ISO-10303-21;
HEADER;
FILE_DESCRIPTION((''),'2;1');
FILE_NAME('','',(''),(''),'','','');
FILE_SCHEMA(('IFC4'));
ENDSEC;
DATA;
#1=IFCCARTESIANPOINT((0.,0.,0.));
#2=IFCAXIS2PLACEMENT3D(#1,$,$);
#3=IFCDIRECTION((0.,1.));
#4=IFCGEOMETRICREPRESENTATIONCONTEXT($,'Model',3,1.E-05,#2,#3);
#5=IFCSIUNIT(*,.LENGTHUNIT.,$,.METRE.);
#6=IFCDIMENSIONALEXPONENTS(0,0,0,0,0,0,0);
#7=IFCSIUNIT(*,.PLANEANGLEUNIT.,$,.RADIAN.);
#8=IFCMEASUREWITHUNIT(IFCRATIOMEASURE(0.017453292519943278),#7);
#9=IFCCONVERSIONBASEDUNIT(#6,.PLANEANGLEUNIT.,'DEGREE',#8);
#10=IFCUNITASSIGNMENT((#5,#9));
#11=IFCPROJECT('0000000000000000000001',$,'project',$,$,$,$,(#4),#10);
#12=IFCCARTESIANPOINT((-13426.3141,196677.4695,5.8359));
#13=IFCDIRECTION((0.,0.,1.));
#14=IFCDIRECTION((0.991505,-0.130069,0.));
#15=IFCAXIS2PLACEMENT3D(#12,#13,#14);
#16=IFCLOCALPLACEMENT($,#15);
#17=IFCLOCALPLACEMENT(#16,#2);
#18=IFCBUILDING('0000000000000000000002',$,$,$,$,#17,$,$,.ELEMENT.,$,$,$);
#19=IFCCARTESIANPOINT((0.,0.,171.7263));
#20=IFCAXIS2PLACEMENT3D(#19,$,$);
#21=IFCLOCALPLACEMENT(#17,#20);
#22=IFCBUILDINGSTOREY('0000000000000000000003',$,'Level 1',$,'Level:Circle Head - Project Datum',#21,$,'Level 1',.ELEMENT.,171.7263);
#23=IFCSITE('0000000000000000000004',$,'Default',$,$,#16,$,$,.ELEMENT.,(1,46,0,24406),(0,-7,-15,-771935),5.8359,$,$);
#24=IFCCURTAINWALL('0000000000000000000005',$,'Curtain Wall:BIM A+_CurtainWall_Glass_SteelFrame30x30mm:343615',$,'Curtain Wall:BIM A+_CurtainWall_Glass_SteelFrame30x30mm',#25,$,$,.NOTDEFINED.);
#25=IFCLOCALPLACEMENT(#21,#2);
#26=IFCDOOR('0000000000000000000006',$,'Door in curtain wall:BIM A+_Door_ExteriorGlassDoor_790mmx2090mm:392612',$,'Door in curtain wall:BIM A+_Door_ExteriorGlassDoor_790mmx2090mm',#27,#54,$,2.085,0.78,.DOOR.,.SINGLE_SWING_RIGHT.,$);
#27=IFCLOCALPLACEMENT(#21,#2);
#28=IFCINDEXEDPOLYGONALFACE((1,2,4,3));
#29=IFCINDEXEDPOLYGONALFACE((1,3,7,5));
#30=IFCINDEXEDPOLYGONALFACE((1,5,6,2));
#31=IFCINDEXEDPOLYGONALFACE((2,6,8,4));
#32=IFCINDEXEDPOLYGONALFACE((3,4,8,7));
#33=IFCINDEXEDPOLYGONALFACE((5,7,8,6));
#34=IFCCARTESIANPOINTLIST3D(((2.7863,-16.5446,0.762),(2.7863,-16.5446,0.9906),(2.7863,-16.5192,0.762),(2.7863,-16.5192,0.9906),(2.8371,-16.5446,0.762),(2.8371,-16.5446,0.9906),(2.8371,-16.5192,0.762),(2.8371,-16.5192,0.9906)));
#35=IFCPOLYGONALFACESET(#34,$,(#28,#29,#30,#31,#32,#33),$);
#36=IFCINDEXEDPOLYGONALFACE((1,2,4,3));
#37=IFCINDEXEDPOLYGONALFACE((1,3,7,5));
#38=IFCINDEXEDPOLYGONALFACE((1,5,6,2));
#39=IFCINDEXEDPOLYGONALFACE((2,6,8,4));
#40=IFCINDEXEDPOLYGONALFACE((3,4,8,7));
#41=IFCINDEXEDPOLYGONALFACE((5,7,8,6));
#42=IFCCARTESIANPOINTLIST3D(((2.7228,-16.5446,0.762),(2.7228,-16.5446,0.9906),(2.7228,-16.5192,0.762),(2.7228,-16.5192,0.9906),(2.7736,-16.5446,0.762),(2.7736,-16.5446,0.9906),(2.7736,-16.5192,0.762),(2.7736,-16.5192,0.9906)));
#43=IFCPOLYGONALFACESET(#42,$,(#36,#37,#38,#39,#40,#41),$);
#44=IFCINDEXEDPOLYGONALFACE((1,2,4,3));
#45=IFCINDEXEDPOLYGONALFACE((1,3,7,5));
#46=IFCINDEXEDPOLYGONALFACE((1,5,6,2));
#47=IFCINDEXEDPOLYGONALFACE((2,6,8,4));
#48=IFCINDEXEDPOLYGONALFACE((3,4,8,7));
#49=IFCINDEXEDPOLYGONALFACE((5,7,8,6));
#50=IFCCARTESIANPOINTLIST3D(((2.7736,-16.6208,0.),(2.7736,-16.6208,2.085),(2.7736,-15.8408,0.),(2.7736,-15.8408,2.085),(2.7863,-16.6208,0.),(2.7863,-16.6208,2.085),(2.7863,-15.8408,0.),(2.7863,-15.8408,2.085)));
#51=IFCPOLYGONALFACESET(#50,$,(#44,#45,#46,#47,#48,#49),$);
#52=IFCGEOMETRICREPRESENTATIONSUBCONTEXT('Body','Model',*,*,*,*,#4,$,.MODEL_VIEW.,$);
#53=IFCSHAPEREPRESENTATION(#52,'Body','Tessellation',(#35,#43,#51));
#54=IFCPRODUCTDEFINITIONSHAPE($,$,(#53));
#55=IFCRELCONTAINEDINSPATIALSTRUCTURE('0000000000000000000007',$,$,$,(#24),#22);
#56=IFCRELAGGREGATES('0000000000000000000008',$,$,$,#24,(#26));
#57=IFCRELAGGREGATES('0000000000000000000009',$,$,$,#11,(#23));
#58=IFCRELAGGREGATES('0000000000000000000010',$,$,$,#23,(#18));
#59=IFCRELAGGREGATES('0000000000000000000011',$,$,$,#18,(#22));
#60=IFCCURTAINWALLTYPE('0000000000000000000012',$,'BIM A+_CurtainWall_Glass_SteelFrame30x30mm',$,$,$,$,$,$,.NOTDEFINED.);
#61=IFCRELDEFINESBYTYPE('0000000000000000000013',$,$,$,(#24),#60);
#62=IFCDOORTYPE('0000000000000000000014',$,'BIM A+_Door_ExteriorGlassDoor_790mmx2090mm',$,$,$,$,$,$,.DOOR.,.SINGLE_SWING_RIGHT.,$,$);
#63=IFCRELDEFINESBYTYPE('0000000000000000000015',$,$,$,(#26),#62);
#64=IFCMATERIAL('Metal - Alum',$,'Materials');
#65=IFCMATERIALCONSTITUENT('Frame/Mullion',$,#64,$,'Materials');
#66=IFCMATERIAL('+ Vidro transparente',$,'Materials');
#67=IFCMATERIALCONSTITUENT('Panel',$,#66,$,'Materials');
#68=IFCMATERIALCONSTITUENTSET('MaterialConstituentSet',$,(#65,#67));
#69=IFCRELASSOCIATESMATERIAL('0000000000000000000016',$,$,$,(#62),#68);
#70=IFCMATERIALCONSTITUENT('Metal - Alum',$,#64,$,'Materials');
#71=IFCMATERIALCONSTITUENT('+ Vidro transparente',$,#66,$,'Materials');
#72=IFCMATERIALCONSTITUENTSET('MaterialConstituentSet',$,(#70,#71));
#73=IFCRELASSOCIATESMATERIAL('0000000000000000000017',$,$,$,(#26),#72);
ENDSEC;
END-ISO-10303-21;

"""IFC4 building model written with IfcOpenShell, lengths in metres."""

from ifc_helpers import new_model, entity, si_unit, converted_unit, direction, frame, origin, place, context, subcontext, project, spatial, indexed_curve, outline, extrude, source, transform, mapped, material, constituent, constituent_set, type_object, type_shapes, element, aggregate, save


model = new_model("IFC4")

# Units and contexts
model_context = context("Model", 3, precision=1e-05, world=origin(), true_north=direction((0.0, 1.0)))
body_context = subcontext(model_context, "Body", "Model", "MODEL_VIEW")
ifc_project = project(units=[si_unit("LENGTHUNIT", "METRE"), converted_unit("PLANEANGLEUNIT", "DEGREE", entity("IfcRatioMeasure", 0.017453292519943278), si_unit("PLANEANGLEUNIT", "RADIAN"), dimensions=[0, 0, 0, 0, 0, 0, 0])], contexts=[model_context])

# Site, building, storey
site_placement = place(None, frame((-13426.3141, 196677.4695, 5.8359), z_axis=(0.0, 0.0, 1.0), x_axis=(0.991505, -0.130069, 0.0)))
site = spatial("IfcSite", under=ifc_project, at=site_placement, Name="Default", CompositionType="ELEMENT", RefLatitude=(1, 46, 0, 24406), RefLongitude=(0, -7, -15, -771935), RefElevation=5.8359)
building_placement = place(site_placement, origin())
building = spatial("IfcBuilding", under=site, at=building_placement, CompositionType="ELEMENT")
storey_placement = place(building_placement, frame((0.0, 0.0, 171.7263)))
storey = spatial("IfcBuildingStorey", under=building, at=storey_placement, Name="Level 1", ObjectType="Level:Circle Head - Project Datum", LongName="Level 1", CompositionType="ELEMENT", Elevation=171.7263)

# Shared definitions
curtain_wall_type_1 = type_object("IfcCurtainWallType", Name="BIM A+_CurtainWall_Glass_SteelFrame30x30mm", PredefinedType="NOTDEFINED")

# Curtain wall, door
curtain_wall_1_placement = place(storey_placement, frame((0.0, 0.0, -171.7263)))
curtain_wall_1 = element("IfcCurtainWall", 1, at=curtain_wall_1_placement, inside=storey, type_object=curtain_wall_type_1, Name="Curtain Wall:BIM A+_CurtainWall_Glass_SteelFrame30x30mm:343615", ObjectType="Curtain Wall:BIM A+_CurtainWall_Glass_SteelFrame30x30mm", PredefinedType="NOTDEFINED")
ifc_material_1 = material(Name="Metal - Alum", Category="Materials")
ifc_constituent_1 = constituent(ifc_material_1, Name="Metal - Alum", Category="Materials")
ifc_material_2 = material(Name="+ Vidro transparente", Category="Materials")
ifc_constituent_2 = constituent(ifc_material_2, Name="+ Vidro transparente", Category="Materials")
ifc_constituent_set_1 = constituent_set(constituents=[ifc_constituent_1, ifc_constituent_2], Name="MaterialConstituentSet")
ifc_constituent_3 = constituent(ifc_material_1, Name="Frame/Mullion", Category="Materials")
ifc_constituent_4 = constituent(ifc_material_2, Name="Panel", Category="Materials")
ifc_constituent_set_2 = constituent_set(constituents=[ifc_constituent_3, ifc_constituent_4], Name="MaterialConstituentSet")
door_type = type_object("IfcDoorType", Name="BIM A+_Door_ExteriorGlassDoor_790mmx2090mm", OperationType="SINGLE_SWING_RIGHT", PredefinedType="DOOR", material=ifc_constituent_set_2)
shared_shape_1 = source(origin(), body_context, "Body", "SweptSolid", [
    extrude(outline(indexed_curve([(-0.0254, -0.0127), (0.0254, -0.0127), (0.0254, 0.0127), (-0.0254, 0.0127), (-0.0254, -0.0127)], self_intersect=False)), frame((-0.3011, -0.0381, 0.762), z_axis=(0.0, 0.0, 1.0), x_axis=(0.0, 1.0, 0.0)), (0.0, 0.0, 1.0), 0.2286),
    extrude(outline(indexed_curve([(-0.0254, -0.0127), (0.0254, -0.0127), (0.0254, 0.0127), (-0.0254, 0.0127), (-0.0254, -0.0127)], self_intersect=False)), frame((-0.3011, 0.0254, 0.762), z_axis=(0.0, 0.0, 1.0), x_axis=(0.0, -1.0, 0.0)), (0.0, 0.0, 1.0), 0.2286),
    extrude(outline(indexed_curve([(-0.39, -0.0064), (0.39, -0.0064), (0.39, 0.0064), (-0.39, 0.0064), (-0.39, -0.0064)], self_intersect=False)), frame((0.0, -0.0063, 0.0), z_axis=(0.0, 0.0, 1.0), x_axis=(-1.0, 0.0, 0.0)), (0.0, 0.0, 1.0), 2.085),
])
type_shapes(door_type, [shared_shape_1])
door_placement = place(curtain_wall_1_placement, frame((2.7736, -16.2308, 171.7263), z_axis=(0.0, 0.0, 1.0), x_axis=(0.0, 1.0, 0.0)))
door = element("IfcDoor", 2, at=door_placement, type_object=door_type, material=ifc_constituent_set_1, Name="Door in curtain wall:BIM A+_Door_ExteriorGlassDoor_790mmx2090mm:392612", ObjectType="Door in curtain wall:BIM A+_Door_ExteriorGlassDoor_790mmx2090mm", OperationType="SINGLE_SWING_RIGHT", OverallHeight=2.085, OverallWidth=0.78, PredefinedType="DOOR", context=body_context, shape_type="MappedRepresentation", body=[
    mapped(shared_shape_1, transform((0.0, 0.0, 0.0), scale=1.0)),
])
aggregate(curtain_wall_1, [door])

save(model, "model.ifc")
